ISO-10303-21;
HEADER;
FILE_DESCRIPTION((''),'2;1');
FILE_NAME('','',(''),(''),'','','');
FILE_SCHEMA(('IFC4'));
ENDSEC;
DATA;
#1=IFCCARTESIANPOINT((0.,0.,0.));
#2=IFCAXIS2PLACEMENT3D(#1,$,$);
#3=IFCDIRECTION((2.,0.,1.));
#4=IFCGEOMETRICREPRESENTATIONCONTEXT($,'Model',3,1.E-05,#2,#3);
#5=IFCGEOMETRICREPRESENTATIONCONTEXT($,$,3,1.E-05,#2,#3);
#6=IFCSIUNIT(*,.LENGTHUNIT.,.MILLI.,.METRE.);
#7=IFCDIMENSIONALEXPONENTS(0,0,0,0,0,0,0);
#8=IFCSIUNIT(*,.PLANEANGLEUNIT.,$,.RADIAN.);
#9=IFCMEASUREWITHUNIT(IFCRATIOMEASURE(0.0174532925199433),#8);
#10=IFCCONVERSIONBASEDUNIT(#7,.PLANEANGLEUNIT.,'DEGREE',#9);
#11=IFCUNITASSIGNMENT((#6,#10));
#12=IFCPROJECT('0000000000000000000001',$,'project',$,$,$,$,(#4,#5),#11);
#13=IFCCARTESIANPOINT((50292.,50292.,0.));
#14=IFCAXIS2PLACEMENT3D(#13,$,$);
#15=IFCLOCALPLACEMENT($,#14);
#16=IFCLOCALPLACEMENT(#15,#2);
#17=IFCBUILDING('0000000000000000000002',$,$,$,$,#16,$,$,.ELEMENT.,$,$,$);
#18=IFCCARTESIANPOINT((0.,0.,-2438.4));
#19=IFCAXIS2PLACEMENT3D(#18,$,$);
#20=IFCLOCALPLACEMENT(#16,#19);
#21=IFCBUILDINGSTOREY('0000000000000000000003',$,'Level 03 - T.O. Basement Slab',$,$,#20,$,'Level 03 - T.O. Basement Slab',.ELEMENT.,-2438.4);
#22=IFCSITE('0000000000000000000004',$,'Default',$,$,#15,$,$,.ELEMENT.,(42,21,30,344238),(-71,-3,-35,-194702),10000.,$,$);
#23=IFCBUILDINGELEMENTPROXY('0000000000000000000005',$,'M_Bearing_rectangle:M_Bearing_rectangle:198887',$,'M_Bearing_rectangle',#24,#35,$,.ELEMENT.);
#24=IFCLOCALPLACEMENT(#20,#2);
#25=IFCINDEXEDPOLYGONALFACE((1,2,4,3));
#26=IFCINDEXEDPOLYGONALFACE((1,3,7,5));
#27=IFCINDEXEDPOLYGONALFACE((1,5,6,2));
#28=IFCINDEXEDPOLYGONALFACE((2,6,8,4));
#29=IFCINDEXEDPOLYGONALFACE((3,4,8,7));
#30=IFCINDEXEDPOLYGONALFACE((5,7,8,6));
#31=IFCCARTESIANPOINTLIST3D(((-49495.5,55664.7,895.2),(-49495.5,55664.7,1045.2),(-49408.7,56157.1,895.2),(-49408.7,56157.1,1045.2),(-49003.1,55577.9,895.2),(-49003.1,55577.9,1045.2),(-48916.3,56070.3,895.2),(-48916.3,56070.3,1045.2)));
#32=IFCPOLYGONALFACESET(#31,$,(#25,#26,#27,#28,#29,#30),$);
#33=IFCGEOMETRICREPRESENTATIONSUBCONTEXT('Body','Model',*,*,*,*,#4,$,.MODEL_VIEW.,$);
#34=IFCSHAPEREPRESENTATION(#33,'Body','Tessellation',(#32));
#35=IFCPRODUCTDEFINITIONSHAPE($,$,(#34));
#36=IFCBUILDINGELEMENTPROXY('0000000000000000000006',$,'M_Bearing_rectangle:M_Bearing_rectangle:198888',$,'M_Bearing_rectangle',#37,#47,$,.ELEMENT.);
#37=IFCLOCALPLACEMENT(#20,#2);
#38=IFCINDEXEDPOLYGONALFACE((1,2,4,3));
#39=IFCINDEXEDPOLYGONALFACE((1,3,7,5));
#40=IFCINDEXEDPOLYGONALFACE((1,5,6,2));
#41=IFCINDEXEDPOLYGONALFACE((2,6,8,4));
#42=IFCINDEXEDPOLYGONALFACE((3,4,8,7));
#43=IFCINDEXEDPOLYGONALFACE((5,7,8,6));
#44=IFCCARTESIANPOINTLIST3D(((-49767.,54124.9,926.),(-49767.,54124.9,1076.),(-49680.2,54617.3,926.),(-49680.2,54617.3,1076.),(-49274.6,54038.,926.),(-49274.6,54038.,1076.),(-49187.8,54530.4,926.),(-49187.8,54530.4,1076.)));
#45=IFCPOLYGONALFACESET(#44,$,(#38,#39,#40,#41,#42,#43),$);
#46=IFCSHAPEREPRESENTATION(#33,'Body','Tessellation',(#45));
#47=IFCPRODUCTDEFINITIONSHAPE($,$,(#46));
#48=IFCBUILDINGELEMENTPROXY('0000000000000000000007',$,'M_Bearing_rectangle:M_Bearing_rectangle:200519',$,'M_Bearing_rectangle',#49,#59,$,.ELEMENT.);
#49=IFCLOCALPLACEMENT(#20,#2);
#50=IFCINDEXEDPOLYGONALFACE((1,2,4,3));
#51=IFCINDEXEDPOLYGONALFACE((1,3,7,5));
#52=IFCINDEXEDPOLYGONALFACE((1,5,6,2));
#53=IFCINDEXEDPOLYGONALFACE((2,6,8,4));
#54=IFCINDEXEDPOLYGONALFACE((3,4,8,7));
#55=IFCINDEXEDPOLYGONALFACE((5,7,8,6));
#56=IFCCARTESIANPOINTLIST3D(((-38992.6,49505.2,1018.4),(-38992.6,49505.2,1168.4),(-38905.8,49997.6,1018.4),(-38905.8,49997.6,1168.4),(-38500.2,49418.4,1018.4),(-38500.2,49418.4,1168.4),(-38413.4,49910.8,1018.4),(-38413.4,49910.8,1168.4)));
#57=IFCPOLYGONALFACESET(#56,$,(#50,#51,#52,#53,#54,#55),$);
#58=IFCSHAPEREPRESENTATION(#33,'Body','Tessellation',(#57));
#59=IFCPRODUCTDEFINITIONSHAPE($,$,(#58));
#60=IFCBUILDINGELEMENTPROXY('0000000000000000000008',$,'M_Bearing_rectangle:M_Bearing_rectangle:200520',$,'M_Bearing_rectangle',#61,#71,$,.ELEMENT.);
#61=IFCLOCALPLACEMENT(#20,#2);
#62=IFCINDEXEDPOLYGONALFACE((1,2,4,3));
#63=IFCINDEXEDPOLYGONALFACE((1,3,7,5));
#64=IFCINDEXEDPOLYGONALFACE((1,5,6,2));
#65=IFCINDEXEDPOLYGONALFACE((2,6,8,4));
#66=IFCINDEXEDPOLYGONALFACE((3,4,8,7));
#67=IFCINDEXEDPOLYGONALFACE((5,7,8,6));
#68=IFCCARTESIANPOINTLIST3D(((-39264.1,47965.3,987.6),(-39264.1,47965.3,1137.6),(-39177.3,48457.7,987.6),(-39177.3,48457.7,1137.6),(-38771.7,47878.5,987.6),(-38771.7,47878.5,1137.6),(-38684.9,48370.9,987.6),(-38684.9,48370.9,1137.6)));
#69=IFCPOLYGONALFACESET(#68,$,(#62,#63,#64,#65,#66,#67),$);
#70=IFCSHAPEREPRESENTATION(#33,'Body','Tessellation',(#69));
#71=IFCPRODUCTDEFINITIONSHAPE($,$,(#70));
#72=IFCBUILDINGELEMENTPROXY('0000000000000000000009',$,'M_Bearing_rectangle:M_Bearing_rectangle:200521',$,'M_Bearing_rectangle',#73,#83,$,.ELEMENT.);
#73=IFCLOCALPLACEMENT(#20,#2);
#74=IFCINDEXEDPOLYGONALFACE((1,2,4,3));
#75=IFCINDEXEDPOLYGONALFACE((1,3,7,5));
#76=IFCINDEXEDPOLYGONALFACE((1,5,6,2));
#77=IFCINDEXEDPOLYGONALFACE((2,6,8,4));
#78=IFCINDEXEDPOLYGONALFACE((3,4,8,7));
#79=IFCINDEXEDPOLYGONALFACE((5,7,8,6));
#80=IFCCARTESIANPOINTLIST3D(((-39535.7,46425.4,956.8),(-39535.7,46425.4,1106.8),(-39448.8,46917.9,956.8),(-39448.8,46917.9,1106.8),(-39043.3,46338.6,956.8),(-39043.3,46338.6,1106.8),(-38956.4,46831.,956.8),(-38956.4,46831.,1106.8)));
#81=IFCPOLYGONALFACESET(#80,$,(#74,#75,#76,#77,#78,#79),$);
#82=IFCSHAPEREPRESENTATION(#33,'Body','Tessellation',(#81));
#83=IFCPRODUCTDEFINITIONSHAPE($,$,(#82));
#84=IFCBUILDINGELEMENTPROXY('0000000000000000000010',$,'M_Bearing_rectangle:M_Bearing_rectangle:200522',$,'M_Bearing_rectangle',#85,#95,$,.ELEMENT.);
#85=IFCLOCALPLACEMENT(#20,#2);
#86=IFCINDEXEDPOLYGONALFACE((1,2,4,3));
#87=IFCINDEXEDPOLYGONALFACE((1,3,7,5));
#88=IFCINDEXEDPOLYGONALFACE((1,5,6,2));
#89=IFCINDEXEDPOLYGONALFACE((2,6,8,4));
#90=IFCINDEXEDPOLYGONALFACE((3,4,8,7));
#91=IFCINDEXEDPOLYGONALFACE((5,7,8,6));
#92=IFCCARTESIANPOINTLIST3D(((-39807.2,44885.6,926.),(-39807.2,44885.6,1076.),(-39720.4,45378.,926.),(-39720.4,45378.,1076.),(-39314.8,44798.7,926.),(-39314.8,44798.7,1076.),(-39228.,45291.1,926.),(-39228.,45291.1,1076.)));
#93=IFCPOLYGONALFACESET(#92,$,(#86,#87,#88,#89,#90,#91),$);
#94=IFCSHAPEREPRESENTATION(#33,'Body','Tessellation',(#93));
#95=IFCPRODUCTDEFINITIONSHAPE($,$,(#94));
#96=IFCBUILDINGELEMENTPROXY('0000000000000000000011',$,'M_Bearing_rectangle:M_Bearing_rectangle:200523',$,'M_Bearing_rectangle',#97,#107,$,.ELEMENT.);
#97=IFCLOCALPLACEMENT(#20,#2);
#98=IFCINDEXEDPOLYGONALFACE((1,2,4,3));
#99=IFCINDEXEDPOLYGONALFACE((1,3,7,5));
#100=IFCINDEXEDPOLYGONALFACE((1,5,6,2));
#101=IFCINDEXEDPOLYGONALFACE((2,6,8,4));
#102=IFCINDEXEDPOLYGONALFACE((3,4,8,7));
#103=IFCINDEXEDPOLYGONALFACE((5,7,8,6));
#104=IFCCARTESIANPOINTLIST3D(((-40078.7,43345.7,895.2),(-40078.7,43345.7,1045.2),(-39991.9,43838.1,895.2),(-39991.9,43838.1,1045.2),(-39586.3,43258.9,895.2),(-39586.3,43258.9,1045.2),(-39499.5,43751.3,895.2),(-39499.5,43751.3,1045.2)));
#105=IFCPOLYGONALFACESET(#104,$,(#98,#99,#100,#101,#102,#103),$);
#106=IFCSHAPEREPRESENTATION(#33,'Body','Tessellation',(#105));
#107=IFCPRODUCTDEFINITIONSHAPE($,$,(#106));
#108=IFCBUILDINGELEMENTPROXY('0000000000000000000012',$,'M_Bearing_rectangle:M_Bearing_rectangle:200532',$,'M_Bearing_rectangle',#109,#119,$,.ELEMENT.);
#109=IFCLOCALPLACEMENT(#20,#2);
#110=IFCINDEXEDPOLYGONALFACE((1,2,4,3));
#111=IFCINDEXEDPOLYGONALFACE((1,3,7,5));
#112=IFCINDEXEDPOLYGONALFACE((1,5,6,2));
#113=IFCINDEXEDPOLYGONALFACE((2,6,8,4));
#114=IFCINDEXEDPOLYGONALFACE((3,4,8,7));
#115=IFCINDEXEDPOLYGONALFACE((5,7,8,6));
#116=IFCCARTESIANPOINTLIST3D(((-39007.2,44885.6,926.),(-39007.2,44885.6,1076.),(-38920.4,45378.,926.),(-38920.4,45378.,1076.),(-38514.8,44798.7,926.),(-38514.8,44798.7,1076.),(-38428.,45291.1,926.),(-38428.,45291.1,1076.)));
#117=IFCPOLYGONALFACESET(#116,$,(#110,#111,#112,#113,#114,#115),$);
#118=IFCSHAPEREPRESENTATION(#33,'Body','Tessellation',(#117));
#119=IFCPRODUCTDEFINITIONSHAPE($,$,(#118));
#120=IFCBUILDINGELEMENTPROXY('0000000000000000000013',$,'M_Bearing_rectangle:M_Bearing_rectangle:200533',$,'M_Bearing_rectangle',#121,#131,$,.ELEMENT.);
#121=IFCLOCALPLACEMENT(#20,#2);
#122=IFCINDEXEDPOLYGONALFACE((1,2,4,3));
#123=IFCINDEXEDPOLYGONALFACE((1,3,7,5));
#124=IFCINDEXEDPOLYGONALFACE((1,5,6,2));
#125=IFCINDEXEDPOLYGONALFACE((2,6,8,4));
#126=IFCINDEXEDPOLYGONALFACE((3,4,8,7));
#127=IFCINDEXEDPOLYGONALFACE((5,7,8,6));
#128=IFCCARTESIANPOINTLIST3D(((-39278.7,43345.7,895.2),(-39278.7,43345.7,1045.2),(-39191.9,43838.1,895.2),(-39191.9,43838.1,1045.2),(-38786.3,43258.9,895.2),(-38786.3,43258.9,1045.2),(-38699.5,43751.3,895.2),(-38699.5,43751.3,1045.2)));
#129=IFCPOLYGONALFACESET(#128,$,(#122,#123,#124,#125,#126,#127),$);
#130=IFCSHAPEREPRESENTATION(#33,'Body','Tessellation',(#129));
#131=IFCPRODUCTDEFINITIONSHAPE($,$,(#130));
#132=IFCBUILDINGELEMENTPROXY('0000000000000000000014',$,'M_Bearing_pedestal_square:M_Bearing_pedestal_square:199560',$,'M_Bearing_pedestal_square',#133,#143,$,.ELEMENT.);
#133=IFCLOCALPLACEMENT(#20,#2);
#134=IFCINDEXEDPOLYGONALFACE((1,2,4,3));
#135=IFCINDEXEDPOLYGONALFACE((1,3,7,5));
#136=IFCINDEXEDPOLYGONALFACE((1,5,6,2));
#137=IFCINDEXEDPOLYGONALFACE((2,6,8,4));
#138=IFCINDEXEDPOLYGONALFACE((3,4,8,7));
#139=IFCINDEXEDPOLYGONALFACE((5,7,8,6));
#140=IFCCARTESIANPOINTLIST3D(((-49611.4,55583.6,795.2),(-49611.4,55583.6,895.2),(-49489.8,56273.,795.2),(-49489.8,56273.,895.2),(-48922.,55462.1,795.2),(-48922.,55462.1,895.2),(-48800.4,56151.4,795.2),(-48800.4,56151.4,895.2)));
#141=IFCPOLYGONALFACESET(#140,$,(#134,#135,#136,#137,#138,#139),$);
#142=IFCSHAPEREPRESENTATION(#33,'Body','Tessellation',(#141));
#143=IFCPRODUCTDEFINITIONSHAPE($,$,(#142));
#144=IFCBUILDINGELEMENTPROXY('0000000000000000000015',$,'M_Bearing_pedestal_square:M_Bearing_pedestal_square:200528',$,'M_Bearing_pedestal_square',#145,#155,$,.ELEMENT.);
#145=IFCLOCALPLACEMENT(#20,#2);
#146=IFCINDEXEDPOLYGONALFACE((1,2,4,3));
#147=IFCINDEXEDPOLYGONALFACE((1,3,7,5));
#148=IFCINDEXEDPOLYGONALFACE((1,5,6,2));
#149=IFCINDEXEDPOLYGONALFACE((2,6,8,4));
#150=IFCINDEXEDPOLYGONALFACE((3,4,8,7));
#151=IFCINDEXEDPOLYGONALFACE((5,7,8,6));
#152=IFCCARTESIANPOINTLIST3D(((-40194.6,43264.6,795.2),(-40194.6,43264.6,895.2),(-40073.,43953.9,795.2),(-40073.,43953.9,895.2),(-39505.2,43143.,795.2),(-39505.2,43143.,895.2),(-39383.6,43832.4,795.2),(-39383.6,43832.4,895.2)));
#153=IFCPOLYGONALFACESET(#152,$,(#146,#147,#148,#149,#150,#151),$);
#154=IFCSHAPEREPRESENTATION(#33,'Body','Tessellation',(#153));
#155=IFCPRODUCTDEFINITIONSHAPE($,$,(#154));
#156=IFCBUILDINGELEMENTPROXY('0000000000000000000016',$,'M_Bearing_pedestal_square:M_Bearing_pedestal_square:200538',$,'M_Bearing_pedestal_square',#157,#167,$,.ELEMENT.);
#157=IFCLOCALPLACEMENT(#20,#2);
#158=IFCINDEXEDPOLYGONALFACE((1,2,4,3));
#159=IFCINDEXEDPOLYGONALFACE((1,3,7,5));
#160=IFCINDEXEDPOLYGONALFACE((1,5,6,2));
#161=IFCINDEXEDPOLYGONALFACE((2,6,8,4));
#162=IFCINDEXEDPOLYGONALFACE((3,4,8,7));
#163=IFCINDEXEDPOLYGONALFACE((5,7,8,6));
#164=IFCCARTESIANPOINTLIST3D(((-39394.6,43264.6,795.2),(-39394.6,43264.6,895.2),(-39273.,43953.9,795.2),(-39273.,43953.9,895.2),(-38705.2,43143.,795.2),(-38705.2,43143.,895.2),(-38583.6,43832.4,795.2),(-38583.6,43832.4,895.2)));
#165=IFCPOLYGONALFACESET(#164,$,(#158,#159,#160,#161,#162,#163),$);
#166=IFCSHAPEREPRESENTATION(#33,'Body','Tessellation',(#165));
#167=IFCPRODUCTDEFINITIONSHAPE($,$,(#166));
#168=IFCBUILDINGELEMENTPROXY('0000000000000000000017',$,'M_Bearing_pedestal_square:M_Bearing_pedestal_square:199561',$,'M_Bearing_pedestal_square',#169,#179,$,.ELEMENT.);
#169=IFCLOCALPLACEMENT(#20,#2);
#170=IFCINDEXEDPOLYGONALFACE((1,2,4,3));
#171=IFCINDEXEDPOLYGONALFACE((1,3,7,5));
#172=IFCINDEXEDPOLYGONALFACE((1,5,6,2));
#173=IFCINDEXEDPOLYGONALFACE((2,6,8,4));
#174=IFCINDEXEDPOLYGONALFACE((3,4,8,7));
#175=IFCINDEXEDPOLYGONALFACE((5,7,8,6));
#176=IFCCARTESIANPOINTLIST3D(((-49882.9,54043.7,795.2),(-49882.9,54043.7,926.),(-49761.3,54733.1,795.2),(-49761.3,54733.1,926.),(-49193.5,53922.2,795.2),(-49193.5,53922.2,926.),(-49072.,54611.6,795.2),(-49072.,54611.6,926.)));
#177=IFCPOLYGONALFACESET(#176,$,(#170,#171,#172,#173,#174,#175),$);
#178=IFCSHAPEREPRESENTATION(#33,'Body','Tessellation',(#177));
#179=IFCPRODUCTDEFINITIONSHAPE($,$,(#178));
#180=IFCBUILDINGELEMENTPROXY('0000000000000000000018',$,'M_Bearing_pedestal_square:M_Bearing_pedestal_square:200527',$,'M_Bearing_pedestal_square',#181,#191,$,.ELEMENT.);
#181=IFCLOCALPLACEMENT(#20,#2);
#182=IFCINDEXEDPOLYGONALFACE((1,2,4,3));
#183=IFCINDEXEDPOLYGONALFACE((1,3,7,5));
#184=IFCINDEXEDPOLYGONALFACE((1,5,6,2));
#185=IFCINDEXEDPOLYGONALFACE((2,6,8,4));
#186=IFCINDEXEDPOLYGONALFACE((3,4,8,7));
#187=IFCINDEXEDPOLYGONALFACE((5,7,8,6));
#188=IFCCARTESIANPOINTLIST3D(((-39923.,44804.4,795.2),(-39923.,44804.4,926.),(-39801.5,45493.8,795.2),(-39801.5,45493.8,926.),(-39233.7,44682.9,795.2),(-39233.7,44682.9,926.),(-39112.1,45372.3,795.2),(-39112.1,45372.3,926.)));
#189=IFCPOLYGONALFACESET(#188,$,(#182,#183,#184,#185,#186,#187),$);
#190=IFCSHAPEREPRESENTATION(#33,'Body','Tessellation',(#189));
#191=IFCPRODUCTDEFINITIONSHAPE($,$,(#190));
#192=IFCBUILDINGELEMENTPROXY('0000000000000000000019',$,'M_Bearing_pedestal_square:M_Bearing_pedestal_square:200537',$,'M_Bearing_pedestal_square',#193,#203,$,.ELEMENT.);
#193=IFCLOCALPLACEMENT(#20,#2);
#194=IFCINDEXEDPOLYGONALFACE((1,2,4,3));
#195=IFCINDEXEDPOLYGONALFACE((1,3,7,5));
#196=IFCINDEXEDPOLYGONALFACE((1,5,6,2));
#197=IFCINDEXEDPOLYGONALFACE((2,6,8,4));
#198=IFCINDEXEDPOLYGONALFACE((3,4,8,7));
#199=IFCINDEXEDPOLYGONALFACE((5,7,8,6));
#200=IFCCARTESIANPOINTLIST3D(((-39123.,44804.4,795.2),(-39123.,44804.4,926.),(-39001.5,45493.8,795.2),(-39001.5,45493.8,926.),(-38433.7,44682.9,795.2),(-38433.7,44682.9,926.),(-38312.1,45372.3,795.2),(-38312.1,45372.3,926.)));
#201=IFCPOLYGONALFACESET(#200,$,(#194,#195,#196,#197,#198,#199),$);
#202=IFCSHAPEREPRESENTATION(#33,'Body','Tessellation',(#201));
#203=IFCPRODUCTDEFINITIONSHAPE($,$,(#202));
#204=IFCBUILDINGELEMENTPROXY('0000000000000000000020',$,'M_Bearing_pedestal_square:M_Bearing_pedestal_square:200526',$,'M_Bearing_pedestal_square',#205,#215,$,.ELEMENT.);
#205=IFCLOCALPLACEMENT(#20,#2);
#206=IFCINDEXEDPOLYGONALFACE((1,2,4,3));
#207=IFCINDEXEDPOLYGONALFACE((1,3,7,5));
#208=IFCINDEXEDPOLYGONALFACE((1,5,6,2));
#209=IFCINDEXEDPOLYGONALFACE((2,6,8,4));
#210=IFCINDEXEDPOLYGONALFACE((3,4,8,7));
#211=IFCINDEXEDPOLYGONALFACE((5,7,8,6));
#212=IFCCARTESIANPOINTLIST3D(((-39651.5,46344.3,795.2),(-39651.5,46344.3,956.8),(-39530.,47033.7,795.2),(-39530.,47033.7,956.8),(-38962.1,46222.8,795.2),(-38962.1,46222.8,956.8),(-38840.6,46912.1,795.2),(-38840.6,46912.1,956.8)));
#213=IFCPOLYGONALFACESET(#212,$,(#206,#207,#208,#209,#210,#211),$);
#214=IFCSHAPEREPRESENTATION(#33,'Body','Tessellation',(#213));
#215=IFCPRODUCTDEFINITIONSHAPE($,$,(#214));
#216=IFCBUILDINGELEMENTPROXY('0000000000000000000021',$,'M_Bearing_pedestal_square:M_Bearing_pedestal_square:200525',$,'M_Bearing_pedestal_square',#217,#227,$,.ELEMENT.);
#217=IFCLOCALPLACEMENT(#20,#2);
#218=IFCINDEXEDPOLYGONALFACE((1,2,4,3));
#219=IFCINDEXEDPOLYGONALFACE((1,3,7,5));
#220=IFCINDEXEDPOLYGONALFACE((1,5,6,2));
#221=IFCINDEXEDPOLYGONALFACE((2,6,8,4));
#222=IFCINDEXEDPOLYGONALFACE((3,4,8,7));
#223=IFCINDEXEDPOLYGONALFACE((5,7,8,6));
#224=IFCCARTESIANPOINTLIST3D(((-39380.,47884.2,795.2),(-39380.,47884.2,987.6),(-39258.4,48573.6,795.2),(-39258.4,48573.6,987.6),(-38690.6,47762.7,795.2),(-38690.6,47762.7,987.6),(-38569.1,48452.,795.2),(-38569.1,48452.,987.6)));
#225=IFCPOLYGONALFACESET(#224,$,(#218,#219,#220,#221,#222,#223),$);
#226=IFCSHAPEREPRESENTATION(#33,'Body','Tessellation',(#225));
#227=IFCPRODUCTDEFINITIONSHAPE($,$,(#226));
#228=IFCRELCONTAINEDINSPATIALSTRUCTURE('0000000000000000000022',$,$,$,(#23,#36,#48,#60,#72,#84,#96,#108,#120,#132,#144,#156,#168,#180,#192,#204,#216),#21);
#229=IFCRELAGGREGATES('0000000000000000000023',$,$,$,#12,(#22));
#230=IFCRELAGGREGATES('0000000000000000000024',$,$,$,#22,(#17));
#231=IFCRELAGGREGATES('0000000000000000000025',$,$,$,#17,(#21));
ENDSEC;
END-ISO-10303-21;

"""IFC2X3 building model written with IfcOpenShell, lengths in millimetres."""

from ifc_helpers import new_model, entity, si_unit, converted_unit, direction, frame, origin, origin_2d_with_axis, place, context, subcontext, project, spatial, rectangle, extrude, source, transform, mapped, element, save


model = new_model("IFC2X3")

# Units and contexts
model_context = context("Model", 3, precision=1e-05, world=origin(), true_north=direction((2.0, 0.0, 1.0)))
context_of_model = context(None, 3, precision=1e-05, world=origin(), true_north=direction((2.0, 0.0, 1.0)))
body_context = subcontext(model_context, "Body", "Model", "MODEL_VIEW")
ifc_project = project(units=[si_unit("LENGTHUNIT", "METRE", prefix="MILLI"), converted_unit("PLANEANGLEUNIT", "DEGREE", entity("IfcRatioMeasure", 0.0174532925199433), si_unit("PLANEANGLEUNIT", "RADIAN"), dimensions=[0, 0, 0, 0, 0, 0, 0])], contexts=[model_context, context_of_model])

# Site, building, storey
site_placement = place(None, frame((50292.0, 50292.0, 0.0)))
site = spatial("IfcSite", under=ifc_project, at=site_placement, Name="Default", CompositionType="ELEMENT", RefLatitude=(42, 21, 30, 344238), RefLongitude=(-71, -3, -35, -194702), RefElevation=10000.0)
building_placement = place(site_placement, origin())
building = spatial("IfcBuilding", under=site, at=building_placement, CompositionType="ELEMENT")
storey_placement = place(building_placement, frame((0.0, 0.0, -2438.4)))
storey = spatial("IfcBuildingStorey", under=building, at=storey_placement, Name="Level 03 - T.O. Basement Slab", LongName="Level 03 - T.O. Basement Slab", CompositionType="ELEMENT", Elevation=-2438.4)

# Building element proxies
shared_shape_1 = source(origin(), body_context, "Body", "SweptSolid", [
    extrude(rectangle(XDim=500.0, YDim=500.0, at=origin_2d_with_axis()), frame((0.0, 0.0, -150.0), z_axis=(0.0, 0.0, 1.0), x_axis=(-1.0, 0.0, 0.0)), (0.0, 0.0, 1.0), 150.0),
])
for number, where, z_axis, x_axis, name in (
    (1, (-49205.9, 55867.5, 1045.2), (0.0, 0.0, 1.0), (0.173648, 0.984808, 0.0), "M_Bearing_rectangle:M_Bearing_rectangle:198887"),
    (2, (-49477.4, 54327.6, 1076.0), (0.0, 0.0, 1.0), (0.173648, 0.984808, 0.0), "M_Bearing_rectangle:M_Bearing_rectangle:198888"),
    (3, (-38703.0, 49708.0, 1168.4), (0.0, 0.0, 1.0), (0.173648, 0.984808, 0.0), "M_Bearing_rectangle:M_Bearing_rectangle:200519"),
    (4, (-38974.5, 48168.1, 1137.6), (0.0, 0.0, 1.0), (0.173648, 0.984808, 0.0), "M_Bearing_rectangle:M_Bearing_rectangle:200520"),
    (5, (-39246.0, 46628.2, 1106.8), (0.0, 0.0, 1.0), (0.173648, 0.984808, 0.0), "M_Bearing_rectangle:M_Bearing_rectangle:200521"),
    (6, (-39517.6, 45088.4, 1076.0), (0.0, 0.0, 1.0), (0.173648, 0.984808, 0.0), "M_Bearing_rectangle:M_Bearing_rectangle:200522"),
    (7, (-39789.1, 43548.5, 1045.2), (0.0, 0.0, 1.0), (0.173648, 0.984808, 0.0), "M_Bearing_rectangle:M_Bearing_rectangle:200523"),
    (8, (-38717.6, 45088.4, 1076.0), (0.0, 0.0, 1.0), (0.173648, 0.984808, 0.0), "M_Bearing_rectangle:M_Bearing_rectangle:200532"),
    (9, (-38989.1, 43548.5, 1045.2), (0.0, 0.0, 1.0), (0.173648, 0.984808, 0.0), "M_Bearing_rectangle:M_Bearing_rectangle:200533"),
):
    element("IfcBuildingElementProxy", number, at=place(storey_placement, frame(where, z_axis=z_axis, x_axis=x_axis)), inside=storey, Name=name, ObjectType="M_Bearing_rectangle", CompositionType="ELEMENT", context=body_context, shape_type="MappedRepresentation", body=[
        mapped(shared_shape_1, transform((0.0, 0.0, 0.0), scale=1.0)),
    ])
shared_shape_2 = source(origin(), body_context, "Body", "SweptSolid", [
    extrude(rectangle(XDim=700.0, YDim=700.0, at=origin_2d_with_axis()), frame((0.0, 0.0, -100.0)), (0.0, 0.0, 1.0), 100.0),
])
for number, where, z_axis, x_axis, name in (
    (10, (-49205.9, 55867.5, 895.2), (0.0, 0.0, 1.0), (0.173648, 0.984808, 0.0), "M_Bearing_pedestal_square:M_Bearing_pedestal_square:199560"),
    (11, (-39789.1, 43548.5, 895.2), (0.0, 0.0, 1.0), (0.173648, 0.984808, 0.0), "M_Bearing_pedestal_square:M_Bearing_pedestal_square:200528"),
    (12, (-38989.1, 43548.5, 895.2), (0.0, 0.0, 1.0), (0.173648, 0.984808, 0.0), "M_Bearing_pedestal_square:M_Bearing_pedestal_square:200538"),
):
    element("IfcBuildingElementProxy", number, at=place(storey_placement, frame(where, z_axis=z_axis, x_axis=x_axis)), inside=storey, Name=name, ObjectType="M_Bearing_pedestal_square", CompositionType="ELEMENT", context=body_context, shape_type="MappedRepresentation", body=[
        mapped(shared_shape_2, transform((0.0, 0.0, 0.0), scale=1.0)),
    ])
shared_shape_3 = source(origin(), body_context, "Body", "SweptSolid", [
    extrude(rectangle(XDim=700.0, YDim=700.0, at=origin_2d_with_axis()), frame((0.0, 0.0, -130.8)), (0.0, 0.0, 1.0), 130.8),
])
for number, where, z_axis, x_axis, name in (
    (13, (-49477.4, 54327.6, 926.0), (0.0, 0.0, 1.0), (0.173648, 0.984808, 0.0), "M_Bearing_pedestal_square:M_Bearing_pedestal_square:199561"),
    (14, (-39517.6, 45088.4, 926.0), (0.0, 0.0, 1.0), (0.173648, 0.984808, 0.0), "M_Bearing_pedestal_square:M_Bearing_pedestal_square:200527"),
    (15, (-38717.6, 45088.4, 926.0), (0.0, 0.0, 1.0), (0.173648, 0.984808, 0.0), "M_Bearing_pedestal_square:M_Bearing_pedestal_square:200537"),
):
    element("IfcBuildingElementProxy", number, at=place(storey_placement, frame(where, z_axis=z_axis, x_axis=x_axis)), inside=storey, Name=name, ObjectType="M_Bearing_pedestal_square", CompositionType="ELEMENT", context=body_context, shape_type="MappedRepresentation", body=[
        mapped(shared_shape_3, transform((0.0, 0.0, 0.0), scale=1.0)),
    ])
shared_shape_4 = source(origin(), body_context, "Body", "SweptSolid", [
    extrude(rectangle(XDim=700.0, YDim=700.0, at=origin_2d_with_axis()), frame((0.0, 0.0, -161.6)), (0.0, 0.0, 1.0), 161.6),
])
proxy_1_placement = place(storey_placement, frame((-39246.0, 46628.2, 956.8), z_axis=(0.0, 0.0, 1.0), x_axis=(0.173648, 0.984808, 0.0)))
element("IfcBuildingElementProxy", 16, at=proxy_1_placement, inside=storey, Name="M_Bearing_pedestal_square:M_Bearing_pedestal_square:200526", ObjectType="M_Bearing_pedestal_square", CompositionType="ELEMENT", context=body_context, shape_type="MappedRepresentation", body=[
    mapped(shared_shape_4, transform((0.0, 0.0, 0.0), scale=1.0)),
])
shared_shape_5 = source(origin(), body_context, "Body", "SweptSolid", [
    extrude(rectangle(XDim=700.0, YDim=700.0, at=origin_2d_with_axis()), frame((0.0, 0.0, -192.4)), (0.0, 0.0, 1.0), 192.4),
])
proxy_2_placement = place(storey_placement, frame((-38974.5, 48168.1, 987.6), z_axis=(0.0, 0.0, 1.0), x_axis=(0.173648, 0.984808, 0.0)))
element("IfcBuildingElementProxy", 17, at=proxy_2_placement, inside=storey, Name="M_Bearing_pedestal_square:M_Bearing_pedestal_square:200525", ObjectType="M_Bearing_pedestal_square", CompositionType="ELEMENT", context=body_context, shape_type="MappedRepresentation", body=[
    mapped(shared_shape_5, transform((0.0, 0.0, 0.0), scale=1.0)),
])

save(model, "model.ifc")
